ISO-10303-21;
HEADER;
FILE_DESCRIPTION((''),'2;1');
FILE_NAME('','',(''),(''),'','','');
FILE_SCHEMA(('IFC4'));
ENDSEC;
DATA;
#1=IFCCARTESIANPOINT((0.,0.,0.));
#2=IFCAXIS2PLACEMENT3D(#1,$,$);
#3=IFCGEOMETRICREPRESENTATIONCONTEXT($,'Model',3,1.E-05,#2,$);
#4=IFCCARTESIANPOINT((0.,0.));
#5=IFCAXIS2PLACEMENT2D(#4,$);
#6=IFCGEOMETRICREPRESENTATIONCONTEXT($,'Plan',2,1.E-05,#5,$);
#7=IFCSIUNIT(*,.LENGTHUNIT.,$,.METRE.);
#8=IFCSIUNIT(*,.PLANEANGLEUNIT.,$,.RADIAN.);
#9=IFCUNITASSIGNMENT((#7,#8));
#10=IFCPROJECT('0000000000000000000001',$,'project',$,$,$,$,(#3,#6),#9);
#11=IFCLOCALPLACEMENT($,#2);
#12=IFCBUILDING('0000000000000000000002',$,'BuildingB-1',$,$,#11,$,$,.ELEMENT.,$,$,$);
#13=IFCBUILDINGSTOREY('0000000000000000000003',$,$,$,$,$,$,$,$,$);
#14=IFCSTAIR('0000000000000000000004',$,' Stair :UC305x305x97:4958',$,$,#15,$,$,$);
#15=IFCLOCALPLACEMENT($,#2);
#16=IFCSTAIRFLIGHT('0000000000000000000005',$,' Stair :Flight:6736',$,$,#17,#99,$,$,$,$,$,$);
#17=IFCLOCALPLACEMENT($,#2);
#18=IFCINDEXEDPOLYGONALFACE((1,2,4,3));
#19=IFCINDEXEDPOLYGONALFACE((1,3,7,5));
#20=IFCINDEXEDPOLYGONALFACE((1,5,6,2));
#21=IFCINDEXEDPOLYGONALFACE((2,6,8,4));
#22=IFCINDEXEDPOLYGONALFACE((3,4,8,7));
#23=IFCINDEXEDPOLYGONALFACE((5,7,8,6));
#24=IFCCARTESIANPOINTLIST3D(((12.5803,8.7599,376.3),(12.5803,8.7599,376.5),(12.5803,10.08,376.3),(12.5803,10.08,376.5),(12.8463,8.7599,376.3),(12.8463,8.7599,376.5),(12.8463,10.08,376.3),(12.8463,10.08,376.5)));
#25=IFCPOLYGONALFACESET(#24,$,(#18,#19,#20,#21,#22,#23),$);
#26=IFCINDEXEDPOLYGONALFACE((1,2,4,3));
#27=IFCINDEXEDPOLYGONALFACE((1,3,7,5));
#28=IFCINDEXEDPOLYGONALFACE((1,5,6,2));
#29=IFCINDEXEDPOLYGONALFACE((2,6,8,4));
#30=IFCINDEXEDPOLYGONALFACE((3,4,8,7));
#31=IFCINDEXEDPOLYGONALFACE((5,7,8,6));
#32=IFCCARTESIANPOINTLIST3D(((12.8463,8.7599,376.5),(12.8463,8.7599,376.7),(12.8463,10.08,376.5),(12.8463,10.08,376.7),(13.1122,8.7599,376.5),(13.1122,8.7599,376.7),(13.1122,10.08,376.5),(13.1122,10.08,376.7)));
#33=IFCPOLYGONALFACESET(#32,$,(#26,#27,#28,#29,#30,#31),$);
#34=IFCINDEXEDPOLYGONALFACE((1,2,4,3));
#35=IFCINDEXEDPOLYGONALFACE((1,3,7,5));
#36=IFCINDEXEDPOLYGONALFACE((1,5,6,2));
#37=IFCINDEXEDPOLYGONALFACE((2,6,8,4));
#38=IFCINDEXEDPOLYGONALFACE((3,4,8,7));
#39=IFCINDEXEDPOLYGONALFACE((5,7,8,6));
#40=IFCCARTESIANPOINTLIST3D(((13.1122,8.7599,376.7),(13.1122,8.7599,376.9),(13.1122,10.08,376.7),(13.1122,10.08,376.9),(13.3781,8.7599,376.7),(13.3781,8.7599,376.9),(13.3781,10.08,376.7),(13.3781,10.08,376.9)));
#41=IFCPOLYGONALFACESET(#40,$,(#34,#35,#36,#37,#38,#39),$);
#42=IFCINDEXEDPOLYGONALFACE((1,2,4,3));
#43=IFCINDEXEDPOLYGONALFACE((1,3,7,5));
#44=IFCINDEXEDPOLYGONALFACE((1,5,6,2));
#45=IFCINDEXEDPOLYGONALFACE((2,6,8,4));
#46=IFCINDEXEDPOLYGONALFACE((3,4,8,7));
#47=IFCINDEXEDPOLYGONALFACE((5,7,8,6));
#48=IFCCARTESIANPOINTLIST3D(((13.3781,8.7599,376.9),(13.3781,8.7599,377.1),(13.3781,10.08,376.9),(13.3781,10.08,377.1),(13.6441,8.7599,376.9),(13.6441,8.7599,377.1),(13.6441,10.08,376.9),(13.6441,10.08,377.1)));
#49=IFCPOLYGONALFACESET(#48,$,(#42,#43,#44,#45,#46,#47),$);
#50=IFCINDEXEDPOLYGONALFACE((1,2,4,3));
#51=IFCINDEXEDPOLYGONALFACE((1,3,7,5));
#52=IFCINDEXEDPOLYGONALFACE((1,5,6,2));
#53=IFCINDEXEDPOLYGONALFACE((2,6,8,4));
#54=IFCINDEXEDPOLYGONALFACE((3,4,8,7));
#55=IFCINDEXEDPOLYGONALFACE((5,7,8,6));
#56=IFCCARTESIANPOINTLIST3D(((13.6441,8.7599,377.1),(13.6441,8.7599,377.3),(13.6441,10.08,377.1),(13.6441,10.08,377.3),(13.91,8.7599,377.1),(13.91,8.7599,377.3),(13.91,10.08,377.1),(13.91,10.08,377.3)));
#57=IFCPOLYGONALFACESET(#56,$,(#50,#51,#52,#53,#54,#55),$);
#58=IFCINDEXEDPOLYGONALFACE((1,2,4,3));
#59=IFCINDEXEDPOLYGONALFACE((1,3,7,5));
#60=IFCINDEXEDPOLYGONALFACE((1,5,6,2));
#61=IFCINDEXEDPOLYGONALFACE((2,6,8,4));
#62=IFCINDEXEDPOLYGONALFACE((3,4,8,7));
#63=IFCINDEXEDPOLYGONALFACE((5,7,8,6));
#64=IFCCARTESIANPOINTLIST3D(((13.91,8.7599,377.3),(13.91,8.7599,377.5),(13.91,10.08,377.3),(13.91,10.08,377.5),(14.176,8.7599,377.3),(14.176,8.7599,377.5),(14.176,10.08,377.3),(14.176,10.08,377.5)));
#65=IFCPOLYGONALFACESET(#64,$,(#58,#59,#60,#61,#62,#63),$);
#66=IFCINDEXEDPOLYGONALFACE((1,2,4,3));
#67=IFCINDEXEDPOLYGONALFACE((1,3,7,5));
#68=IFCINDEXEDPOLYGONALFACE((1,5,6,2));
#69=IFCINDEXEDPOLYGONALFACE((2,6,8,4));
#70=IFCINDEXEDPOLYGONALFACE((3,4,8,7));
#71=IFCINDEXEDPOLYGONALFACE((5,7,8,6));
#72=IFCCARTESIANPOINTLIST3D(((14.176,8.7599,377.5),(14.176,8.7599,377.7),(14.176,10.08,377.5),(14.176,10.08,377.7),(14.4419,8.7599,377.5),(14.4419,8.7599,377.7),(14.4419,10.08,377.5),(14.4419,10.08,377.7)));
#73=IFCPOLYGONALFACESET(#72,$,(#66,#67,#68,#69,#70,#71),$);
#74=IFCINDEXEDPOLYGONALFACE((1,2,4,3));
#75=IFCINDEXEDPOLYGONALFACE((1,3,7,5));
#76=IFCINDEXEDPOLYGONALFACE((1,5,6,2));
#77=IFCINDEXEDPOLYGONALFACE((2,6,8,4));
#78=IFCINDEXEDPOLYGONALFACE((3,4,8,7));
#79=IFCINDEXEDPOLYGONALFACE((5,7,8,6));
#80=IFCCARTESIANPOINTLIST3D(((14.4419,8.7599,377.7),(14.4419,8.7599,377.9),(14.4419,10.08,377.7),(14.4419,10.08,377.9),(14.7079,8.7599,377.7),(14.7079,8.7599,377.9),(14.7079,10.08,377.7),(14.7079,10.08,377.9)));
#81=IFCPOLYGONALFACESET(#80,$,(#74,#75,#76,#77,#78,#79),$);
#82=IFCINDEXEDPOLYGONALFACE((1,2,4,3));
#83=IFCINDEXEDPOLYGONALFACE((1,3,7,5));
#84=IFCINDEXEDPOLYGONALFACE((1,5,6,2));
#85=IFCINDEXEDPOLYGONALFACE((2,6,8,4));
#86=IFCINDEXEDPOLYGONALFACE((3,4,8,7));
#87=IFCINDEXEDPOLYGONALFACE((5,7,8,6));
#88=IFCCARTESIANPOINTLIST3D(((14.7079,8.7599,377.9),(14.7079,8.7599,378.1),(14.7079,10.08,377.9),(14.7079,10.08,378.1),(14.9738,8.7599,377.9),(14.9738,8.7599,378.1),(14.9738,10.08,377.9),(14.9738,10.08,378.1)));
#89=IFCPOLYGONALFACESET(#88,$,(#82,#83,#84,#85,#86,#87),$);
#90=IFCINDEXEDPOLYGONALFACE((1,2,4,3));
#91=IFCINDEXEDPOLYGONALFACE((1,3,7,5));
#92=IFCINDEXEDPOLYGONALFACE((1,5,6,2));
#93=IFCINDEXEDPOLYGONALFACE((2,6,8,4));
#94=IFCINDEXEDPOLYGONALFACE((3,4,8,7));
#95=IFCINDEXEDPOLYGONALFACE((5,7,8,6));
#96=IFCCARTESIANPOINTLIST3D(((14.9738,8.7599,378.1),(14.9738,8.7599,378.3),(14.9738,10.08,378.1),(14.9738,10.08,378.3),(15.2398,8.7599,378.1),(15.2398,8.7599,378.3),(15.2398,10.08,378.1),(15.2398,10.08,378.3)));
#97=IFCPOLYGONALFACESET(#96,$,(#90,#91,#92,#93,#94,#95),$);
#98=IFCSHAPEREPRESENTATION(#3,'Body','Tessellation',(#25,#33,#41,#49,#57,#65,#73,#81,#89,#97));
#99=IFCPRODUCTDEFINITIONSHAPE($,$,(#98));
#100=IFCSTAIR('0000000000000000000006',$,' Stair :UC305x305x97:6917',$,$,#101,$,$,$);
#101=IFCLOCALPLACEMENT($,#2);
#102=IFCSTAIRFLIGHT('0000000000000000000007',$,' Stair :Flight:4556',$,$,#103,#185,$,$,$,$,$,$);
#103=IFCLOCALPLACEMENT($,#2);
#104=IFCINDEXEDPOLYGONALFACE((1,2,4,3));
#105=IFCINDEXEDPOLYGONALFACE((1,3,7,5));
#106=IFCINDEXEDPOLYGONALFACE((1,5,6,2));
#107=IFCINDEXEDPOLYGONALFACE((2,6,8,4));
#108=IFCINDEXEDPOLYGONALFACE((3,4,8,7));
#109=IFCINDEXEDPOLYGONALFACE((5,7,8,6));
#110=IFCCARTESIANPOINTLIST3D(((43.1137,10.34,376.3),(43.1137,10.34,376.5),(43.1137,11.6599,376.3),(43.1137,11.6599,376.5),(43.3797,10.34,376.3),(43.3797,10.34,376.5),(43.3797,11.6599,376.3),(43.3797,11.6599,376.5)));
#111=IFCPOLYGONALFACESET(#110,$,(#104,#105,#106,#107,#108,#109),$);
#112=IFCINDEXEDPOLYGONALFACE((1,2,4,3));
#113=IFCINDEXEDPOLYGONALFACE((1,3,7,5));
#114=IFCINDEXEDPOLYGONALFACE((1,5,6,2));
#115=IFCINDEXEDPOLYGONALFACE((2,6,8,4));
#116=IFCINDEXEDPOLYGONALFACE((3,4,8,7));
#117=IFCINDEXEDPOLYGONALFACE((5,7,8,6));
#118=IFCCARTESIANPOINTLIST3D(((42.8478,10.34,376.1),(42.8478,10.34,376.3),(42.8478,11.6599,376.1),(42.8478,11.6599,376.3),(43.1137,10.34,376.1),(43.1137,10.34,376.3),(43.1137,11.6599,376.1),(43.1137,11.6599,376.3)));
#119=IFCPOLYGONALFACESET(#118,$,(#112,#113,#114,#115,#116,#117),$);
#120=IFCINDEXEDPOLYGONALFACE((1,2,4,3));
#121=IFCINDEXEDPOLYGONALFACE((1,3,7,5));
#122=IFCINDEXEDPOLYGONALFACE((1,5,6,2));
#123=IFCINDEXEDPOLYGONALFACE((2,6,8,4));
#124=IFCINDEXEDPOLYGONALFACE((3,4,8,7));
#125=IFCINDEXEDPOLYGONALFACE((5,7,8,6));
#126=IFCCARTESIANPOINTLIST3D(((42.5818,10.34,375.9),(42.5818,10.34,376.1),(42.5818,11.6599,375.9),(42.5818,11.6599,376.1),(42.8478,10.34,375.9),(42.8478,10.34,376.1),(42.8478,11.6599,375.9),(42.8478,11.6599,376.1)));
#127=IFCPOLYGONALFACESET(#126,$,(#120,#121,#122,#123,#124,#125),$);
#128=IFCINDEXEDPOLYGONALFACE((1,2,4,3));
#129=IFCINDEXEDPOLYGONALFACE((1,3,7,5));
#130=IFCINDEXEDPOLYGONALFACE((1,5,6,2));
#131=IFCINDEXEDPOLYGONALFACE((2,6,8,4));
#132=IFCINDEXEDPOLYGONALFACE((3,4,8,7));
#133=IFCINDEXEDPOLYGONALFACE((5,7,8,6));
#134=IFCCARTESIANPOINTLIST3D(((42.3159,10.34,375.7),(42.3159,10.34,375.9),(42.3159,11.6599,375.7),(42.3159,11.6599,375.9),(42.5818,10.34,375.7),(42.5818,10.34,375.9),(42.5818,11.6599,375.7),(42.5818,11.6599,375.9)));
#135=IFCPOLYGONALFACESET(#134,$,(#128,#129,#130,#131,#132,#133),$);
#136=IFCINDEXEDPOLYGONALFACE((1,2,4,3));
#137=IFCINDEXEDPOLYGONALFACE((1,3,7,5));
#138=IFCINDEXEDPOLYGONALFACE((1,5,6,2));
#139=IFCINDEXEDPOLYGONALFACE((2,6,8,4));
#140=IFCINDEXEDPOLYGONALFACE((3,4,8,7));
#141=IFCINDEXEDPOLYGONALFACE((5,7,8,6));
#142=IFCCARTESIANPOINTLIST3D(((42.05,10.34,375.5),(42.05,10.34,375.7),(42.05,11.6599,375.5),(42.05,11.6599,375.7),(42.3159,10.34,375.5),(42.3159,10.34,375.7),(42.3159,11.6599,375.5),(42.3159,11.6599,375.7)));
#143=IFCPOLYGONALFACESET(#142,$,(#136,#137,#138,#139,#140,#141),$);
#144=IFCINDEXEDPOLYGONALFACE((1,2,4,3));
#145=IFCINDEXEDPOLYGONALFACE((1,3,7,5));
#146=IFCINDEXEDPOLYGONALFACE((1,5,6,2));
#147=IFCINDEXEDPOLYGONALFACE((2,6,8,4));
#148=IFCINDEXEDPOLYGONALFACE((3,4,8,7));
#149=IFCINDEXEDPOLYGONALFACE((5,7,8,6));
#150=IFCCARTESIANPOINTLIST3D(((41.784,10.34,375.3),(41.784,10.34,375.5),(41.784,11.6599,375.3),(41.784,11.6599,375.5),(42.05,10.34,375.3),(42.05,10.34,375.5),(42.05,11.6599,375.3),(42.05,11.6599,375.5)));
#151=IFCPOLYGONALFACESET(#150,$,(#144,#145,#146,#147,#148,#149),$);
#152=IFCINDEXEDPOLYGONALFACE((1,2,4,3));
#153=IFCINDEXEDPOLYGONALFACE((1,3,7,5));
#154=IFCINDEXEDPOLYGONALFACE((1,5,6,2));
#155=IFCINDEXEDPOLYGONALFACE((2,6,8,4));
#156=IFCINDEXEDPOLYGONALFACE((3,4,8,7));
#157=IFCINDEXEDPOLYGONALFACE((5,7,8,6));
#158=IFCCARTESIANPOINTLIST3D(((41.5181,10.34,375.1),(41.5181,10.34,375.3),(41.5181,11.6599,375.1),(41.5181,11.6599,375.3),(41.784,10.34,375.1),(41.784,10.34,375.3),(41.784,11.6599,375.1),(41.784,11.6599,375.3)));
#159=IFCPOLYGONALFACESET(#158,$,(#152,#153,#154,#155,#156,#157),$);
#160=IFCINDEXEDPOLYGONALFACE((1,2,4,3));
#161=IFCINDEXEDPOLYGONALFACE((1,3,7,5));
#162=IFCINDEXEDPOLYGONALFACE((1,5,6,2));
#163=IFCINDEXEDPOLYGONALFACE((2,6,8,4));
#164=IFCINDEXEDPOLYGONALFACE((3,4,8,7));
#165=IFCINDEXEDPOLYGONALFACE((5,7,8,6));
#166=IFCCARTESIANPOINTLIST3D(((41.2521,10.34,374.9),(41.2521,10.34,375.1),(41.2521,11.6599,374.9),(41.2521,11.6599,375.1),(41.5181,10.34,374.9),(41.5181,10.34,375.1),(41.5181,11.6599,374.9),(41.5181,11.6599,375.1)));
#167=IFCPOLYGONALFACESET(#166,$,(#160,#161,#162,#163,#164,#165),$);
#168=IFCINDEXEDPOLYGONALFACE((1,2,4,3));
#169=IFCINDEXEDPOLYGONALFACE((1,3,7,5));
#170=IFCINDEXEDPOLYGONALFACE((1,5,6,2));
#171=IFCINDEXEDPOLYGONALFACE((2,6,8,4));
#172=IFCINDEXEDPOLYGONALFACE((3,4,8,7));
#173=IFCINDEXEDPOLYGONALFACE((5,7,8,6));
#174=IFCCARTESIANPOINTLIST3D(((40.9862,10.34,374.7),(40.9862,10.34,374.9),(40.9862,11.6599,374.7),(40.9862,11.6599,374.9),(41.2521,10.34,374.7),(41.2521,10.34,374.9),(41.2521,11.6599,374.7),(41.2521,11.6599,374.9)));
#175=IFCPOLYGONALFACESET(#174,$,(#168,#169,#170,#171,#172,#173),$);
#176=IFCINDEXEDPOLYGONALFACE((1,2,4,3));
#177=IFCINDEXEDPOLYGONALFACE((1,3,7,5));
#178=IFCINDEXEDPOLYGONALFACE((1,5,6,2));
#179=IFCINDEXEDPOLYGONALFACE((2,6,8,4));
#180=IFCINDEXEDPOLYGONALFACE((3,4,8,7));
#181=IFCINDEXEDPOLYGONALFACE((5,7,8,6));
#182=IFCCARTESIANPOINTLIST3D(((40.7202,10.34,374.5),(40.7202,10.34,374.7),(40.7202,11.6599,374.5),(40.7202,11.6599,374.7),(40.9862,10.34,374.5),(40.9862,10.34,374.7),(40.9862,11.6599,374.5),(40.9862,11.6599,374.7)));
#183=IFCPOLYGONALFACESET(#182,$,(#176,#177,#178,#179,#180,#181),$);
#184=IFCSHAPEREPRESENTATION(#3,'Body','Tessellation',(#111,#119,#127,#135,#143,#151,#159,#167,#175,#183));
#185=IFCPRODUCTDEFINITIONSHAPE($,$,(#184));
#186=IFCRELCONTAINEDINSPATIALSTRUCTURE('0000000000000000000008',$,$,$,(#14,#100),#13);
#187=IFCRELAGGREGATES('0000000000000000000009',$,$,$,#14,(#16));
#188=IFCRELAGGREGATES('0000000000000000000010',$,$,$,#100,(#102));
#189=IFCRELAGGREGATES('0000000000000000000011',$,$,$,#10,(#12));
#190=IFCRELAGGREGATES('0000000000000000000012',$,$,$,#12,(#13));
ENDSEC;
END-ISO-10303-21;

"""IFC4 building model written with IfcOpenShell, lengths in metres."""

from ifc_helpers import new_model, si_unit, frame, origin, origin_2d, place, context, project, spatial, polyline, outline, extrude, element, aggregate, save


model = new_model("IFC4")

# Units and contexts
model_context = context("Model", 3, precision=1e-05, world=origin())
plan_context = context("Plan", 2, precision=1e-05, world=origin_2d())
ifc_project = project(units=[si_unit("LENGTHUNIT", "METRE"), si_unit("PLANEANGLEUNIT", "RADIAN")], contexts=[model_context, plan_context])

# Building, storey
building_placement = place(None, origin())
building = spatial("IfcBuilding", under=ifc_project, at=building_placement, Name="BuildingB-1", CompositionType="ELEMENT")
storey = spatial("IfcBuildingStorey", under=building)

# Stairs, stair flights
stair_1 = element("IfcStair", 1, inside=storey, Name=" Stair :UC305x305x97:4958")
stair_flight_1 = element("IfcStairFlight", 2, Name=" Stair :Flight:6736", context=model_context, shape_type="SweptSolid", body=[
    extrude(outline(polyline([(12.8463, 8.7599, 376.5), (12.8463, 10.08, 376.5), (12.5803, 10.08, 376.5), (12.5803, 8.7599, 376.5), (12.8463, 8.7599, 376.5)])), origin(), (0.0, 0.0, -1.0), 0.2),
    extrude(outline(polyline([(13.1122, 8.7599, 376.5), (13.1122, 10.08, 376.5), (12.8463, 10.08, 376.5), (12.8463, 8.7599, 376.5), (13.1122, 8.7599, 376.5)])), frame((0.0, 0.0, 0.2)), (0.0, 0.0, -1.0), 0.2),
    extrude(outline(polyline([(13.3781, 8.7599, 376.5), (13.3781, 10.08, 376.5), (13.1122, 10.08, 376.5), (13.1122, 8.7599, 376.5), (13.3781, 8.7599, 376.5)])), frame((0.0, 0.0, 0.4)), (0.0, 0.0, -1.0), 0.2),
    extrude(outline(polyline([(13.6441, 8.7599, 376.5), (13.6441, 10.08, 376.5), (13.3781, 10.08, 376.5), (13.3781, 8.7599, 376.5), (13.6441, 8.7599, 376.5)])), frame((0.0, 0.0, 0.6)), (0.0, 0.0, -1.0), 0.2),
    extrude(outline(polyline([(13.91, 8.7599, 376.5), (13.91, 10.08, 376.5), (13.6441, 10.08, 376.5), (13.6441, 8.7599, 376.5), (13.91, 8.7599, 376.5)])), frame((0.0, 0.0, 0.8)), (0.0, 0.0, -1.0), 0.2),
    extrude(outline(polyline([(14.176, 8.7599, 376.5), (14.176, 10.08, 376.5), (13.91, 10.08, 376.5), (13.91, 8.7599, 376.5), (14.176, 8.7599, 376.5)])), frame((0.0, 0.0, 1.0)), (0.0, 0.0, -1.0), 0.2),
    extrude(outline(polyline([(14.4419, 8.7599, 376.5), (14.4419, 10.08, 376.5), (14.176, 10.08, 376.5), (14.176, 8.7599, 376.5), (14.4419, 8.7599, 376.5)])), frame((0.0, 0.0, 1.2)), (0.0, 0.0, -1.0), 0.2),
    extrude(outline(polyline([(14.7079, 8.7599, 376.5), (14.7079, 10.08, 376.5), (14.4419, 10.08, 376.5), (14.4419, 8.7599, 376.5), (14.7079, 8.7599, 376.5)])), frame((0.0, 0.0, 1.4)), (0.0, 0.0, -1.0), 0.2),
    extrude(outline(polyline([(14.9738, 8.7599, 376.5), (14.9738, 10.08, 376.5), (14.7079, 10.08, 376.5), (14.7079, 8.7599, 376.5), (14.9738, 8.7599, 376.5)])), frame((0.0, 0.0, 1.6)), (0.0, 0.0, -1.0), 0.2),
    extrude(outline(polyline([(15.2398, 8.7599, 376.5), (15.2398, 10.08, 376.5), (14.9738, 10.08, 376.5), (14.9738, 8.7599, 376.5), (15.2398, 8.7599, 376.5)])), frame((0.0, 0.0, 1.8)), (0.0, 0.0, -1.0), 0.2),
])
aggregate(stair_1, [stair_flight_1])
stair_2 = element("IfcStair", 3, inside=storey, Name=" Stair :UC305x305x97:6917")
stair_flight_2 = element("IfcStairFlight", 4, Name=" Stair :Flight:4556", context=model_context, shape_type="SweptSolid", body=[
    extrude(outline(polyline([(43.1137, 11.6599, 376.5), (43.1137, 10.34, 376.5), (43.3797, 10.34, 376.5), (43.3797, 11.6599, 376.5), (43.1137, 11.6599, 376.5)])), origin(), (0.0, 0.0, -1.0), 0.2),
    extrude(outline(polyline([(42.8478, 11.6599, 376.5), (42.8478, 10.34, 376.5), (43.1137, 10.34, 376.5), (43.1137, 11.6599, 376.5), (42.8478, 11.6599, 376.5)])), frame((0.0, 0.0, -0.2)), (0.0, 0.0, -1.0), 0.2),
    extrude(outline(polyline([(42.5818, 11.6599, 376.5), (42.5818, 10.34, 376.5), (42.8478, 10.34, 376.5), (42.8478, 11.6599, 376.5), (42.5818, 11.6599, 376.5)])), frame((0.0, 0.0, -0.4)), (0.0, 0.0, -1.0), 0.2),
    extrude(outline(polyline([(42.3159, 11.6599, 376.5), (42.3159, 10.34, 376.5), (42.5818, 10.34, 376.5), (42.5818, 11.6599, 376.5), (42.3159, 11.6599, 376.5)])), frame((0.0, 0.0, -0.6)), (0.0, 0.0, -1.0), 0.2),
    extrude(outline(polyline([(42.05, 11.6599, 376.5), (42.05, 10.34, 376.5), (42.3159, 10.34, 376.5), (42.3159, 11.6599, 376.5), (42.05, 11.6599, 376.5)])), frame((0.0, 0.0, -0.8)), (0.0, 0.0, -1.0), 0.2),
    extrude(outline(polyline([(41.784, 11.6599, 376.5), (41.784, 10.34, 376.5), (42.05, 10.34, 376.5), (42.05, 11.6599, 376.5), (41.784, 11.6599, 376.5)])), frame((0.0, 0.0, -1.0)), (0.0, 0.0, -1.0), 0.2),
    extrude(outline(polyline([(41.5181, 11.6599, 376.5), (41.5181, 10.34, 376.5), (41.784, 10.34, 376.5), (41.784, 11.6599, 376.5), (41.5181, 11.6599, 376.5)])), frame((0.0, 0.0, -1.2)), (0.0, 0.0, -1.0), 0.2),
    extrude(outline(polyline([(41.2521, 11.6599, 376.5), (41.2521, 10.34, 376.5), (41.5181, 10.34, 376.5), (41.5181, 11.6599, 376.5), (41.2521, 11.6599, 376.5)])), frame((0.0, 0.0, -1.4)), (0.0, 0.0, -1.0), 0.2),
    extrude(outline(polyline([(40.9862, 11.6599, 376.5), (40.9862, 10.34, 376.5), (41.2521, 10.34, 376.5), (41.2521, 11.6599, 376.5), (40.9862, 11.6599, 376.5)])), frame((0.0, 0.0, -1.6)), (0.0, 0.0, -1.0), 0.2),
    extrude(outline(polyline([(40.7202, 11.6599, 376.5), (40.7202, 10.34, 376.5), (40.9862, 10.34, 376.5), (40.9862, 11.6599, 376.5), (40.7202, 11.6599, 376.5)])), frame((0.0, 0.0, -1.8)), (0.0, 0.0, -1.0), 0.2),
])
aggregate(stair_2, [stair_flight_2])

save(model, "model.ifc")
